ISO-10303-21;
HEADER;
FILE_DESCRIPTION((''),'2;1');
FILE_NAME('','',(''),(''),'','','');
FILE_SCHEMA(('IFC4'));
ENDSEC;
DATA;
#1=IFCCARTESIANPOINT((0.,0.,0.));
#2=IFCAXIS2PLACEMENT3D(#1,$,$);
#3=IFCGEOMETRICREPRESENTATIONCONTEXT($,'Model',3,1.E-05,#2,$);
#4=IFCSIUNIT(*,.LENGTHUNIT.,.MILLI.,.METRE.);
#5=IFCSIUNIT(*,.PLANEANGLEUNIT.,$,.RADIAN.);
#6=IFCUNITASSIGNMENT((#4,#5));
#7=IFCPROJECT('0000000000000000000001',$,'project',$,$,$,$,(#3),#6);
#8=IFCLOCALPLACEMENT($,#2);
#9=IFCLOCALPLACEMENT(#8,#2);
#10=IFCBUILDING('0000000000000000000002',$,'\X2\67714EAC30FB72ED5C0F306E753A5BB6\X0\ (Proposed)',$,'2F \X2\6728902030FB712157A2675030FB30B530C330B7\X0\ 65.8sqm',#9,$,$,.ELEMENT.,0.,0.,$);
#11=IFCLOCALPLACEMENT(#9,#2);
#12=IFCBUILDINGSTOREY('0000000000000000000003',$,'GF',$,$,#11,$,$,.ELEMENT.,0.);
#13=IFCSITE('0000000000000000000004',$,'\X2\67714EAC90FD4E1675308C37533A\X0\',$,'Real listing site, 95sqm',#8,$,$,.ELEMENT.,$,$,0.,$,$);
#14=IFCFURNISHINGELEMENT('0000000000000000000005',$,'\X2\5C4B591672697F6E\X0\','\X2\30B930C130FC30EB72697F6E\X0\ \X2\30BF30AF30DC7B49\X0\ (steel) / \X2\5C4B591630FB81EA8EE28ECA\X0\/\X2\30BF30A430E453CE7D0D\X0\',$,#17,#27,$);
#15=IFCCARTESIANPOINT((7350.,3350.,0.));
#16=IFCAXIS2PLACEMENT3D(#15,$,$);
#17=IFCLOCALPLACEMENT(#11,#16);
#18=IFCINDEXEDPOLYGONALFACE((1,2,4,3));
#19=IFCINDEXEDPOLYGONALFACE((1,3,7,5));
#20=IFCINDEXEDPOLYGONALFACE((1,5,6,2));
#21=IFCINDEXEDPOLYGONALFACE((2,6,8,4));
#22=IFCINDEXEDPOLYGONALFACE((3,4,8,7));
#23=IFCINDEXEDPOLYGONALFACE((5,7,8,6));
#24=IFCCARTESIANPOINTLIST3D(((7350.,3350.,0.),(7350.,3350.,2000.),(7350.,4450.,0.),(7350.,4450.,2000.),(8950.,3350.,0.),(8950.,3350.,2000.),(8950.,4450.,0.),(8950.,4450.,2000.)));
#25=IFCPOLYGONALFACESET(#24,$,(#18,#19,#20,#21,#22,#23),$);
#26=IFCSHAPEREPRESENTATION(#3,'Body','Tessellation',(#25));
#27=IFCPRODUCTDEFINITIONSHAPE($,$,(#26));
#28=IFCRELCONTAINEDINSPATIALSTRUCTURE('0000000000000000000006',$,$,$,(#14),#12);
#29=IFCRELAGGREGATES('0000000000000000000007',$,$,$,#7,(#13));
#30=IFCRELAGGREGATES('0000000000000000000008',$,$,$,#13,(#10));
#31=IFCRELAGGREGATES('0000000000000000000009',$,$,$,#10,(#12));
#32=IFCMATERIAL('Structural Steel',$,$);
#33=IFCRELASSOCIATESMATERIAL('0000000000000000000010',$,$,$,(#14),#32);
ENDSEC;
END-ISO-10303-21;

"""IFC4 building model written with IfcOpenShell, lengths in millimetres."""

from ifc_helpers import new_model, si_unit, frame, frame_2d, origin, place, context, project, spatial, rectangle, extrude, material, element, save


model = new_model("IFC4")

# Units and contexts
model_context = context("Model", 3, precision=1e-05, world=origin())
ifc_project = project(units=[si_unit("LENGTHUNIT", "METRE", prefix="MILLI"), si_unit("PLANEANGLEUNIT", "RADIAN")], contexts=[model_context])

# Site, building, storey
site_placement = place(None, origin())
site = spatial("IfcSite", under=ifc_project, at=site_placement, Name="東京都世田谷区", ObjectType="Real listing site, 95sqm", CompositionType="ELEMENT", RefElevation=0.0)
building_placement = place(site_placement, origin())
building = spatial("IfcBuilding", under=site, at=building_placement, Name="東京・狭小の町家 (Proposed)", ObjectType="2F 木造・無垢材・サッシ 65.8sqm", CompositionType="ELEMENT", ElevationOfRefHeight=0.0, ElevationOfTerrain=0.0)
storey_placement = place(building_placement, origin())
storey = spatial("IfcBuildingStorey", under=building, at=storey_placement, Name="GF", CompositionType="ELEMENT", Elevation=0.0)

# Shared definitions
ifc_material_1 = material(Name="Structural Steel")

# Furnishing element
furnishing_1_placement = place(storey_placement, frame((7350.0, 3350.0, 0.0)))
element("IfcFurnishingElement", 1, at=furnishing_1_placement, inside=storey, material=ifc_material_1, Name="屋外物置", Description="スチール物置 タクボ等 (steel) / 屋外・自転車/タイヤ収納", context=model_context, shape_type="SweptSolid", body=[
    extrude(rectangle(XDim=1600.0, YDim=1100.0, at=frame_2d((800.0, 550.0))), frame((7350.0, 3350.0, 0.0)), (0.0, 0.0, 1.0), 2000.0),
])

save(model, "model.ifc")
